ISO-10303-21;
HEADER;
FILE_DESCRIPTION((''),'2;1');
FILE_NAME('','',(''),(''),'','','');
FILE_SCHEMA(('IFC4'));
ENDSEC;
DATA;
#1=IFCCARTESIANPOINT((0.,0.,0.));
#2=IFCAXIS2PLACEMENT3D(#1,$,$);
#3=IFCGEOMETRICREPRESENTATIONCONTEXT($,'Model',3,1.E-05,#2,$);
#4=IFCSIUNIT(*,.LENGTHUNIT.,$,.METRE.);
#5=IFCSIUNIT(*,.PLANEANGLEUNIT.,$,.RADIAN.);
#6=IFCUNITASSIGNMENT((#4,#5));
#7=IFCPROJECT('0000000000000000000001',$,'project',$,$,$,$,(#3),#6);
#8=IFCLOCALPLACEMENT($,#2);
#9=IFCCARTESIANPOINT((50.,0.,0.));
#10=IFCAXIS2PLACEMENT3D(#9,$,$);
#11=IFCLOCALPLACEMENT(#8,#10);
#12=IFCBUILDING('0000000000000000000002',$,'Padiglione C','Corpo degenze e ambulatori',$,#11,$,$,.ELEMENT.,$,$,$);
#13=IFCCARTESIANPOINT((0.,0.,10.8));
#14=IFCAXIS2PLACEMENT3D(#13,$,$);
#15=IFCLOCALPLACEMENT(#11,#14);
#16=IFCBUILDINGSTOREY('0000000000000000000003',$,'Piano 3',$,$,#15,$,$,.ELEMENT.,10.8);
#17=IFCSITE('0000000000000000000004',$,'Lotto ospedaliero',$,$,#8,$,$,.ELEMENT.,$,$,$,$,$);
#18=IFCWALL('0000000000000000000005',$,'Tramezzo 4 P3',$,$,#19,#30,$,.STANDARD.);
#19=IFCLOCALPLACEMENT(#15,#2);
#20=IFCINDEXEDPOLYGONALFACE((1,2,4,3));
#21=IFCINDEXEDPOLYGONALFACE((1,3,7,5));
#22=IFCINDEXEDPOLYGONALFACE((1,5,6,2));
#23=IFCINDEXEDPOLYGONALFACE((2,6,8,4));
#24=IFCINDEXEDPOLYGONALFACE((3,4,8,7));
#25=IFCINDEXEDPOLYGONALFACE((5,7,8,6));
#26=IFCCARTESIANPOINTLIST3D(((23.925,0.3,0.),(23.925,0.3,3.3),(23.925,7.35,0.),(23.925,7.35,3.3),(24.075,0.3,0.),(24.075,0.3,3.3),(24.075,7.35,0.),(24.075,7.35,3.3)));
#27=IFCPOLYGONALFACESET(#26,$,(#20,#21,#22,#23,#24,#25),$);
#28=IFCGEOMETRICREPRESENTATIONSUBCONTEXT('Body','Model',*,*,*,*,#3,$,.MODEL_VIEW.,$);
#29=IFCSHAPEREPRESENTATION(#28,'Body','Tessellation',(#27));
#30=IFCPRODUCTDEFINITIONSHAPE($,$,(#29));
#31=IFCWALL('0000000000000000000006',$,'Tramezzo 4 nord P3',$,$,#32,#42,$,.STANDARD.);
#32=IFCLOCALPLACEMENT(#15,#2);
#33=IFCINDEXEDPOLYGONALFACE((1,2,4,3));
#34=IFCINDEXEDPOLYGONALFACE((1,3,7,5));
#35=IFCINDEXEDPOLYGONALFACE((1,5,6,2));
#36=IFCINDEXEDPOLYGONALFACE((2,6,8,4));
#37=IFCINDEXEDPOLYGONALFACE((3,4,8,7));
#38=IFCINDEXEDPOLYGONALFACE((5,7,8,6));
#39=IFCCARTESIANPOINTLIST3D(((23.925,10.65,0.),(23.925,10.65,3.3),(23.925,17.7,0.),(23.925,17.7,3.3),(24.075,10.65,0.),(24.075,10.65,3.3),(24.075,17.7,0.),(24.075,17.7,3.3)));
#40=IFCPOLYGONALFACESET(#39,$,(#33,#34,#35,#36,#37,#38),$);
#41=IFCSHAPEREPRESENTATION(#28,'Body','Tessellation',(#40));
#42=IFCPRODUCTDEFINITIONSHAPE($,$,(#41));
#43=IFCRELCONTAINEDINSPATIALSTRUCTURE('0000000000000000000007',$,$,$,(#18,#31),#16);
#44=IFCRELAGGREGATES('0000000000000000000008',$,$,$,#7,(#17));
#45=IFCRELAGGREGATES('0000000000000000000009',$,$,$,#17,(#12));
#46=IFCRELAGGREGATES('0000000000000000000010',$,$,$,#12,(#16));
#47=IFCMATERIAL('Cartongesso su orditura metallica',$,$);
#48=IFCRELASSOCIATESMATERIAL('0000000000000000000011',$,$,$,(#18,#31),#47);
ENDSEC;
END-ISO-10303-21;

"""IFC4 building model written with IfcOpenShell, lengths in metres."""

from ifc_helpers import new_model, si_unit, frame, frame_2d, origin, place, context, subcontext, project, spatial, rectangle, extrude, material, element, save


model = new_model("IFC4")

# Units and contexts
model_context = context("Model", 3, precision=1e-05, world=origin())
body_context = subcontext(model_context, "Body", "Model", "MODEL_VIEW")
ifc_project = project(units=[si_unit("LENGTHUNIT", "METRE"), si_unit("PLANEANGLEUNIT", "RADIAN")], contexts=[model_context])

# Site, building, storey
site_placement = place(None, origin())
site = spatial("IfcSite", under=ifc_project, at=site_placement, Name="Lotto ospedaliero", CompositionType="ELEMENT")
building_placement = place(site_placement, frame((50.0, 0.0, 0.0)))
building = spatial("IfcBuilding", under=site, at=building_placement, Name="Padiglione C", Description="Corpo degenze e ambulatori", CompositionType="ELEMENT")
storey_placement = place(building_placement, frame((0.0, 0.0, 10.8)))
storey = spatial("IfcBuildingStorey", under=building, at=storey_placement, Name="Piano 3", CompositionType="ELEMENT", Elevation=10.8)

# Walls
ifc_material_1 = material(Name="Cartongesso su orditura metallica")
for number, where, name in (
    (1, (23.925, 0.3, 0.0), "Tramezzo 4 P3"),
    (2, (23.925, 10.65, 0.0), "Tramezzo 4 nord P3"),
):
    element("IfcWall", number, at=place(storey_placement, frame(where)), inside=storey, material=ifc_material_1, Name=name, PredefinedType="STANDARD", context=body_context, shape_type="SweptSolid", body=[
        extrude(rectangle(XDim=0.15, YDim=7.05, at=frame_2d((0.075, 3.525))), origin(), (0.0, 0.0, 1.0), 3.3),
    ])

save(model, "model.ifc")
